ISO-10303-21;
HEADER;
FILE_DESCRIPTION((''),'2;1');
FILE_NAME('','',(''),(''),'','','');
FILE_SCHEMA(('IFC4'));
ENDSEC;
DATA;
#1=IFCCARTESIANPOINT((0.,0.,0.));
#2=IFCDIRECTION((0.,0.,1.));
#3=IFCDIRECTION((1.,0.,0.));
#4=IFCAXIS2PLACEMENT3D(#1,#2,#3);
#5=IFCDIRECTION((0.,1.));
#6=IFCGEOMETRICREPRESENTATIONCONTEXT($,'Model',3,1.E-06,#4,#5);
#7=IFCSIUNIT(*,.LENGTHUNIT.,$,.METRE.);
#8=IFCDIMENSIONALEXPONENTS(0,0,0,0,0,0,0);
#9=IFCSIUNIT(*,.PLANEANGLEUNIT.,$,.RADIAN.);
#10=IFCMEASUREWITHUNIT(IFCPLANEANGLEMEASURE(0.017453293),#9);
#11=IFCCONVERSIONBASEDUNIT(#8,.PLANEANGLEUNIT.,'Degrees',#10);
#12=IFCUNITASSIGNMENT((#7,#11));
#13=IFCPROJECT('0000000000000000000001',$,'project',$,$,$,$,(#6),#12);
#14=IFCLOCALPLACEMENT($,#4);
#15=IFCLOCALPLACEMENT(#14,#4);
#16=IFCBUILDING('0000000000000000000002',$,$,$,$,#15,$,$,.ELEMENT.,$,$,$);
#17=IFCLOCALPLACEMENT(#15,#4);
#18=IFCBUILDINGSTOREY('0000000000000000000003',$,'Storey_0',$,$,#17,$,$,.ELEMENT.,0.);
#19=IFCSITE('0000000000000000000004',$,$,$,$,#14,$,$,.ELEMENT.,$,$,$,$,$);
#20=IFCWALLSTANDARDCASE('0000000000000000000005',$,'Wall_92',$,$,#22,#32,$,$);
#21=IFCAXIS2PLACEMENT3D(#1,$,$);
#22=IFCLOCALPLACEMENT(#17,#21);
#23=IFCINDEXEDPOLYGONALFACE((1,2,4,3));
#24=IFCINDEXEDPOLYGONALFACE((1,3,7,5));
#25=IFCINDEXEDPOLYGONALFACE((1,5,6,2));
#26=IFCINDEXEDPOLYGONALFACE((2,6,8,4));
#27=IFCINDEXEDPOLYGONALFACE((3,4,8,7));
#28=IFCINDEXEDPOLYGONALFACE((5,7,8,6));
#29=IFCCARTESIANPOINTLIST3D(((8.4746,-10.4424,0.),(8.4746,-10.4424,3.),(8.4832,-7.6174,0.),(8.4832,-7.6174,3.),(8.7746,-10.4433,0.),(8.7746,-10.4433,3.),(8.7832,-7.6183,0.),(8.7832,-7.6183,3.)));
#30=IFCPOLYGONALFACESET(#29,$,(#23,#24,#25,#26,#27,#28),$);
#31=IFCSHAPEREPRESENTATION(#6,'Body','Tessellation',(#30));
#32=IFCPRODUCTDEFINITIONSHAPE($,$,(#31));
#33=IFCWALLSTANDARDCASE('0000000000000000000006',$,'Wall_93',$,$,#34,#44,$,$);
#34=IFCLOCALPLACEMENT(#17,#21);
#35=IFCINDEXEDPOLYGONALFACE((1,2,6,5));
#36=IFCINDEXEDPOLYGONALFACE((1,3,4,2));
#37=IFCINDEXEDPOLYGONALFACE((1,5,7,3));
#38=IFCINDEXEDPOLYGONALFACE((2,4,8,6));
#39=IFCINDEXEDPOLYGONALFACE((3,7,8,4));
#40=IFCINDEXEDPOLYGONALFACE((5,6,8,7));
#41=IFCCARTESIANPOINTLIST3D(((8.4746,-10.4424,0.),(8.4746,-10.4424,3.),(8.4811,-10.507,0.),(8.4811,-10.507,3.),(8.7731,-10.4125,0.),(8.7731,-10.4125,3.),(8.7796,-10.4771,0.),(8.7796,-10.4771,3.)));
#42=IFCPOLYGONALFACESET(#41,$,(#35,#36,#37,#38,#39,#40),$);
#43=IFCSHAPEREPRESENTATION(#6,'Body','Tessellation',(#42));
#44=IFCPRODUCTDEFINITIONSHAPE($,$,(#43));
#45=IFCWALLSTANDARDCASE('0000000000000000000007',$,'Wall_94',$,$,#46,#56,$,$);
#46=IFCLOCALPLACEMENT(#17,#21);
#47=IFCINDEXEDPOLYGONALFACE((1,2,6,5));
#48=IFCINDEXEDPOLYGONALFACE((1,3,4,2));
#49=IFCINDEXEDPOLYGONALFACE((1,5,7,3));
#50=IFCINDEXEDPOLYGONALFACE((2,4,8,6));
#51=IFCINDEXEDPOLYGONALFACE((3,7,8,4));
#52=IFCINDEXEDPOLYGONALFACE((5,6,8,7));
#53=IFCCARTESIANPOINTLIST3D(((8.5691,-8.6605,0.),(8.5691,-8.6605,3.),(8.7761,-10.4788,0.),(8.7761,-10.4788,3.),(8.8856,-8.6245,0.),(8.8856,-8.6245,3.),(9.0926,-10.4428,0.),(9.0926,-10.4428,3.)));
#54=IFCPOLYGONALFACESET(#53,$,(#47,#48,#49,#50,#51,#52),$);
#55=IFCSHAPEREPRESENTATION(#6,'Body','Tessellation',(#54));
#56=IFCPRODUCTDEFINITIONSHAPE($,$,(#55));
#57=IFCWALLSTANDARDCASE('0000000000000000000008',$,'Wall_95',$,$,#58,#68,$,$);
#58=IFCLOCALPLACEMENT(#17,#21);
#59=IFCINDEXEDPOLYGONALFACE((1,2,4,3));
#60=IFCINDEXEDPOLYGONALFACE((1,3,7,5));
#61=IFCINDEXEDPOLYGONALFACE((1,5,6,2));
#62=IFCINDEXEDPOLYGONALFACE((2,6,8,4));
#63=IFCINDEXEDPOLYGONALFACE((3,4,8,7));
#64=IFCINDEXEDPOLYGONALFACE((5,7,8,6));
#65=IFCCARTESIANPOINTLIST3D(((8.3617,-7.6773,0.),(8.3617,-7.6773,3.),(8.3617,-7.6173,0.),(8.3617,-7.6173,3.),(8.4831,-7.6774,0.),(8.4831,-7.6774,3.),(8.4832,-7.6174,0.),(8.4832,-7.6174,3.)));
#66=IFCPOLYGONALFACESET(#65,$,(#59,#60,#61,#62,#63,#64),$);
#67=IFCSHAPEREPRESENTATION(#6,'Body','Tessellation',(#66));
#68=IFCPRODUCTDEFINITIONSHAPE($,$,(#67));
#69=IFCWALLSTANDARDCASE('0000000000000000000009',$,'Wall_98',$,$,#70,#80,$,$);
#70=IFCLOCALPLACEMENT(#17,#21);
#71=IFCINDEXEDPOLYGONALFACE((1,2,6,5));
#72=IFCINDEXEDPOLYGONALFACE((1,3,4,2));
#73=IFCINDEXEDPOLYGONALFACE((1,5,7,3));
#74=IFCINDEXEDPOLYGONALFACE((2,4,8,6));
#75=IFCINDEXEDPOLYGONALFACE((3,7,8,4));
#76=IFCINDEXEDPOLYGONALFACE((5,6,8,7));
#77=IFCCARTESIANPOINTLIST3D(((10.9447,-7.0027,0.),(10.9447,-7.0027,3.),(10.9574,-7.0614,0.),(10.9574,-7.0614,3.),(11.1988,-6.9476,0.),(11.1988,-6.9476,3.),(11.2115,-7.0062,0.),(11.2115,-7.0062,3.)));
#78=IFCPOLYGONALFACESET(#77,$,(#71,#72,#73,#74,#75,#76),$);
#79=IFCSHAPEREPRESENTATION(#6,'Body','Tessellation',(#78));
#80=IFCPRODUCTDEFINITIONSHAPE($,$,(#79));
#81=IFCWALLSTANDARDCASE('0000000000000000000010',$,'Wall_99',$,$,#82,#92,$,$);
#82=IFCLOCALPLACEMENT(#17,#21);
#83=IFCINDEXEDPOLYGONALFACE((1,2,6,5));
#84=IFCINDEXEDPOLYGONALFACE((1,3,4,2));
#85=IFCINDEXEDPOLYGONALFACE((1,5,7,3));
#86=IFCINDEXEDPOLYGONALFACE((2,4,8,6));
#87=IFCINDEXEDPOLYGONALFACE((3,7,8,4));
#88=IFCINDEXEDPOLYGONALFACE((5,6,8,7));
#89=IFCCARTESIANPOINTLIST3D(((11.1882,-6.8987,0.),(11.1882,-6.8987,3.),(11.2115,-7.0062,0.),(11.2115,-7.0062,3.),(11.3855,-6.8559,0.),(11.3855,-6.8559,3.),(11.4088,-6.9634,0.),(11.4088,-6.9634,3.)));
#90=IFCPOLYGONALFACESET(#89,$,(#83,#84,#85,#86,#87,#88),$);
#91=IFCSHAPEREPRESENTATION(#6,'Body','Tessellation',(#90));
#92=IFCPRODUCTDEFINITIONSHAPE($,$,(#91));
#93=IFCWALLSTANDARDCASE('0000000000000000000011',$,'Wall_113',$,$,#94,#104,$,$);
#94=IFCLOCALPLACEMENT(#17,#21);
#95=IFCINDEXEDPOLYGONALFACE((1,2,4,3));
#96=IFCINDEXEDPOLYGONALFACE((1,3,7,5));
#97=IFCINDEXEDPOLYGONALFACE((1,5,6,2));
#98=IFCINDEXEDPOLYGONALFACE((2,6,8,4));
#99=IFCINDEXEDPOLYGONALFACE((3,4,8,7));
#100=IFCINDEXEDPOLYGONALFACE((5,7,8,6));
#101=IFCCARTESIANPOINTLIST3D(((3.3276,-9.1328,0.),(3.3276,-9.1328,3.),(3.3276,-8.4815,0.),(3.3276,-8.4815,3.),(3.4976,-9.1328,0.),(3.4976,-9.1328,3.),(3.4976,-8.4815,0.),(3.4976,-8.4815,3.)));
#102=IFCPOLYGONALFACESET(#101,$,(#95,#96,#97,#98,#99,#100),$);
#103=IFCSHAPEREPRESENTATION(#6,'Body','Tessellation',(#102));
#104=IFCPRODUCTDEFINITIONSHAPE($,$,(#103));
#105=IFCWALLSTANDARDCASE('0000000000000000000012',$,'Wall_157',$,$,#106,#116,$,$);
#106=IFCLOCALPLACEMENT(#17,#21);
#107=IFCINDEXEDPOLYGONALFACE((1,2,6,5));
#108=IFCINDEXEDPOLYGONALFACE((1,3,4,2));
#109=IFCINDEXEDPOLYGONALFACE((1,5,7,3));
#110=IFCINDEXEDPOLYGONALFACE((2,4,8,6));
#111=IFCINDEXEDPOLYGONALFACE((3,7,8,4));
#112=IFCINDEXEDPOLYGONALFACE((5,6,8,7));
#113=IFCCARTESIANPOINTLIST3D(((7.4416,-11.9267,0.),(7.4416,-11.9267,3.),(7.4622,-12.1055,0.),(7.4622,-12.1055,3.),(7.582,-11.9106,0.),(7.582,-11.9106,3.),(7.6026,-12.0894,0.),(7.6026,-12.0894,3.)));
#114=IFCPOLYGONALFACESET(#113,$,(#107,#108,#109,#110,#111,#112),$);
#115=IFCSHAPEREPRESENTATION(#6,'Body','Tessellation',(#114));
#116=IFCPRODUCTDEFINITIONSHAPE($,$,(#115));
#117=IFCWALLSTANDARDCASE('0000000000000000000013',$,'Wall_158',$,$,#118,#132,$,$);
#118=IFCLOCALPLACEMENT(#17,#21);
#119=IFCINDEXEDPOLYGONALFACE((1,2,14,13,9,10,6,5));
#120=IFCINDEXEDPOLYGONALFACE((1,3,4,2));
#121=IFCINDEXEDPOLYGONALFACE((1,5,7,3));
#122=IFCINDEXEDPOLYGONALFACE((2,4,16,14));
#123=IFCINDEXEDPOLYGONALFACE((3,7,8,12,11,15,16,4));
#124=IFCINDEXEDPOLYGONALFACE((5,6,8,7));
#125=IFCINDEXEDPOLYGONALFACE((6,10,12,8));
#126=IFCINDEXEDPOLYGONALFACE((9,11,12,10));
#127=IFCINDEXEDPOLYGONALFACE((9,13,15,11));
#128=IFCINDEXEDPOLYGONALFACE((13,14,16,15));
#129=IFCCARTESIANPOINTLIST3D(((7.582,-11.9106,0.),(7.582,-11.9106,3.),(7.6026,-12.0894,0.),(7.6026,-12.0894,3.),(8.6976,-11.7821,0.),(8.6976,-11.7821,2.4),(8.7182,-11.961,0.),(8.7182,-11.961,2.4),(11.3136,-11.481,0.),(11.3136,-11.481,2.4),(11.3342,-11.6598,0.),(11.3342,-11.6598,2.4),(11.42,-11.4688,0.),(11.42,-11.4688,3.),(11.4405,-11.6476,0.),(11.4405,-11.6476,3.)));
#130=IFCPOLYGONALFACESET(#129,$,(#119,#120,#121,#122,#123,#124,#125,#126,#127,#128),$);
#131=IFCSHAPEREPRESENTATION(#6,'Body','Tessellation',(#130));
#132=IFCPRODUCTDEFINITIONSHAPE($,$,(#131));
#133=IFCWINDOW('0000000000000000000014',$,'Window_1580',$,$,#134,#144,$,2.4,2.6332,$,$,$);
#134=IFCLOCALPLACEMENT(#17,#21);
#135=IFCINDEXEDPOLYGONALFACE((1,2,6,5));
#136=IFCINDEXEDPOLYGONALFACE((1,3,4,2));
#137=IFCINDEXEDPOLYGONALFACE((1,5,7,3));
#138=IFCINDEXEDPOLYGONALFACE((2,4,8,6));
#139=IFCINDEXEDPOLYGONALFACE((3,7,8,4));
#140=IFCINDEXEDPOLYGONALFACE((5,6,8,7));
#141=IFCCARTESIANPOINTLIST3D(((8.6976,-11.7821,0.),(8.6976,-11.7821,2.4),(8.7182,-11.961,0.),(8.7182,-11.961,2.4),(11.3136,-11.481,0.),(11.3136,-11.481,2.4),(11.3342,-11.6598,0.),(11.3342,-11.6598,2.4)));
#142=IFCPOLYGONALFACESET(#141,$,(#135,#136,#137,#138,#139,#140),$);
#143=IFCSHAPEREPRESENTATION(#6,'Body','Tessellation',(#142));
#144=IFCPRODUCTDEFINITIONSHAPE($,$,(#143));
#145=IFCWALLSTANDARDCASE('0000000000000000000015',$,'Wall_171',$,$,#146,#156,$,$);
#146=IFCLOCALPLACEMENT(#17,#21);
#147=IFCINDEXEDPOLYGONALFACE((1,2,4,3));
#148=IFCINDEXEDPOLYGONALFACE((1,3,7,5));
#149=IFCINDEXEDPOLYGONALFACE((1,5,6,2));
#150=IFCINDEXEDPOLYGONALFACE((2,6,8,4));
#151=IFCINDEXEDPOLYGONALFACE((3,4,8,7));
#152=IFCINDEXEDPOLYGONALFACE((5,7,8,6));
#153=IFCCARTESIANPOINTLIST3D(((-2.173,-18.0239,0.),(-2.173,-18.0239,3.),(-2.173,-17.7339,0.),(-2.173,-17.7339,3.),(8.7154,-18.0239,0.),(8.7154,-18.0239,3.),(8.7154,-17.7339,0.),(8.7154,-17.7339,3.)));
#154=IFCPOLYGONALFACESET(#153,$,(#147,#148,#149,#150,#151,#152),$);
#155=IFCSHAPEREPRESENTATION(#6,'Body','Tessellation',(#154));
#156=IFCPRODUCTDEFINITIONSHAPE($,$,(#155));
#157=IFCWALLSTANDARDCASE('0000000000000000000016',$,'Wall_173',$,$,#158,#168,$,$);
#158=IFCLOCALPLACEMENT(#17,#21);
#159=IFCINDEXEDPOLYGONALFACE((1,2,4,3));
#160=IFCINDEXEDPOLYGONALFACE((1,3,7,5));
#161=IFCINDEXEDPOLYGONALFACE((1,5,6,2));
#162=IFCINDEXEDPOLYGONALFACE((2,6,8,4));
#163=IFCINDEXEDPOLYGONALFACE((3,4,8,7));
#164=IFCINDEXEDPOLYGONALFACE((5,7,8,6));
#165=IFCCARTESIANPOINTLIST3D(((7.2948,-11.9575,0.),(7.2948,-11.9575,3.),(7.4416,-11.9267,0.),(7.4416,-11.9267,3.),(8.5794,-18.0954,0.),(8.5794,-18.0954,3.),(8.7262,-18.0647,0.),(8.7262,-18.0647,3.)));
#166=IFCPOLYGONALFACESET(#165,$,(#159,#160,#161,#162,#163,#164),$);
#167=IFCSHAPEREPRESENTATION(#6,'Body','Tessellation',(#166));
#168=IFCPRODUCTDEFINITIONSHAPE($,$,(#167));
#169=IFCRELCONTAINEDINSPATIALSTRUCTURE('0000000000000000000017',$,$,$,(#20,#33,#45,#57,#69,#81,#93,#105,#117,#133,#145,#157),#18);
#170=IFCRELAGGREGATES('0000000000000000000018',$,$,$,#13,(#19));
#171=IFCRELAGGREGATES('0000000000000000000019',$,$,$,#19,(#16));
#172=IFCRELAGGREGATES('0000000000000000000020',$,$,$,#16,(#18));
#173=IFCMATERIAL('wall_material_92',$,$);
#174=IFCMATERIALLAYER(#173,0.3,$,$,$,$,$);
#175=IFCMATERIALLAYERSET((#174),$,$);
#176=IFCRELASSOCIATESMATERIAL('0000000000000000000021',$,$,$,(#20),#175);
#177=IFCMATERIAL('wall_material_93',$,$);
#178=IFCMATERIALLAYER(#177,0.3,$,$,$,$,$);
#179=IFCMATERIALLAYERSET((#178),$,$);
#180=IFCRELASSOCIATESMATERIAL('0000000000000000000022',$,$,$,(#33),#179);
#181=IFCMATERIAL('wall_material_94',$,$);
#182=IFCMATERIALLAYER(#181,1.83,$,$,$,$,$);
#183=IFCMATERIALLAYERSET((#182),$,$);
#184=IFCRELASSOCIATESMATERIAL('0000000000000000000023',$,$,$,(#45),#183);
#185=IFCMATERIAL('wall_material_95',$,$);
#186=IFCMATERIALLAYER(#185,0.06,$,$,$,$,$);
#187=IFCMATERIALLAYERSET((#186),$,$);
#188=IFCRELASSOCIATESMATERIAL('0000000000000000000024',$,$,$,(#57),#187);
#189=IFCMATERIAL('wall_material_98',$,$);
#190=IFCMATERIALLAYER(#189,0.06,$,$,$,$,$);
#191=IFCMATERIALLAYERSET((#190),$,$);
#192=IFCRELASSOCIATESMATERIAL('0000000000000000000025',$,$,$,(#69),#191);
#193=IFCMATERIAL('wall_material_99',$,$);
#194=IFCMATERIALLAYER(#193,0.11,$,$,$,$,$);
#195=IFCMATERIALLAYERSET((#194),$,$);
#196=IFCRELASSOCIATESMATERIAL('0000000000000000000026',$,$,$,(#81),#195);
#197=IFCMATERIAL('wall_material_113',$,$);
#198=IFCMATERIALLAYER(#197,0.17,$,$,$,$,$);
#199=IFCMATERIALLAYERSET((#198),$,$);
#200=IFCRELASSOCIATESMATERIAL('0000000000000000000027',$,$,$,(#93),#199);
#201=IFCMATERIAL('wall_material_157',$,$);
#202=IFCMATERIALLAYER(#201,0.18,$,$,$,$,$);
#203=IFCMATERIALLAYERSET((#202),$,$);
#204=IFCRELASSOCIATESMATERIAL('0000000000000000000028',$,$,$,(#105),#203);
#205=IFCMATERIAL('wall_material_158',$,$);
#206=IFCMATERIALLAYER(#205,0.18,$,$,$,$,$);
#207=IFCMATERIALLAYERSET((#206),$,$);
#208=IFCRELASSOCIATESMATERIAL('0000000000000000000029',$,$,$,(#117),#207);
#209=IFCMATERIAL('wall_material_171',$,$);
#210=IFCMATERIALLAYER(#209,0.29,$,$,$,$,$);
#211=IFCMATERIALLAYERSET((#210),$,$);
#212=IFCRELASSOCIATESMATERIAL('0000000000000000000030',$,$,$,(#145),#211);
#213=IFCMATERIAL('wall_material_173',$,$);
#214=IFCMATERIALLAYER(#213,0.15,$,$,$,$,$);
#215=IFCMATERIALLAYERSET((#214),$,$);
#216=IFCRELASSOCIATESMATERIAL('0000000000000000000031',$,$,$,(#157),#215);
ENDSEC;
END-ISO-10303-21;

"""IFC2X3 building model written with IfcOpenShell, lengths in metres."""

from ifc_helpers import new_model, entity, si_unit, converted_unit, direction, frame, frame_2d, origin_with_axes, place, context, project, spatial, polyline, rectangle, outline, extrude, material, layer, layer_set, layer_usage, element, fill, save


model = new_model("IFC2X3")

# Units and contexts
model_context = context("Model", 3, precision=1e-06, world=origin_with_axes(), true_north=direction((0.0, 1.0)))
ifc_project = project(units=[si_unit("LENGTHUNIT", "METRE"), converted_unit("PLANEANGLEUNIT", "Degrees", entity("IfcPlaneAngleMeasure", 0.017453293), si_unit("PLANEANGLEUNIT", "RADIAN"), dimensions=[0, 0, 0, 0, 0, 0, 0])], contexts=[model_context])

# Site, building, storey
site_placement = place(None, origin_with_axes())
site = spatial("IfcSite", under=ifc_project, at=site_placement, CompositionType="ELEMENT")
building_placement = place(site_placement, origin_with_axes())
building = spatial("IfcBuilding", under=site, at=building_placement, CompositionType="ELEMENT")
storey_placement = place(building_placement, origin_with_axes())
storey = spatial("IfcBuildingStorey", under=building, at=storey_placement, Name="Storey_0", CompositionType="ELEMENT", Elevation=0.0)

# Walls
ifc_material_1 = material(Name="wall_material_92")
ifc_layer_1 = layer(ifc_material_1, 0.3)
ifc_layer_set_1 = layer_set([ifc_layer_1])
ifc_layer_usage_1 = layer_usage(ifc_layer_set_1, "AXIS2", "POSITIVE", 0.0)
wall_1_placement = place(storey_placement, frame((8.4832, -7.6174, 0.0), z_axis=(0.0, 0.0, 1.0), x_axis=(-0.003012, -0.999995, 0.0)))
element("IfcWallStandardCase", 1, at=wall_1_placement, inside=storey, material=ifc_layer_usage_1, Name="Wall_92", context=model_context, shape_type="SweptSolid", body=[
    extrude(outline(polyline([(0.0, 0.3), (2.825, 0.3), (2.825, 0.0), (0.0, 0.0), (0.0, 0.3)])), origin_with_axes(), (0.0, 0.0, 1.0), 3.0),
])
ifc_material_2 = material(Name="wall_material_93")
ifc_layer_2 = layer(ifc_material_2, 0.3)
ifc_layer_set_2 = layer_set([ifc_layer_2])
ifc_layer_usage_2 = layer_usage(ifc_layer_set_2, "AXIS2", "POSITIVE", 0.0)
wall_2_placement = place(storey_placement, frame((8.4746, -10.4424, 0.0), z_axis=(0.0, 0.0, 1.0), x_axis=(0.099721, -0.995015, 0.0)))
element("IfcWallStandardCase", 2, at=wall_2_placement, inside=storey, material=ifc_layer_usage_2, Name="Wall_93", context=model_context, shape_type="SweptSolid", body=[
    extrude(outline(polyline([(0.0, 0.3), (0.065, 0.3), (0.065, 0.0), (0.0, 0.0), (0.0, 0.3)])), origin_with_axes(), (0.0, 0.0, 1.0), 3.0),
])
ifc_material_3 = material(Name="wall_material_94")
ifc_layer_3 = layer(ifc_material_3, 1.83)
ifc_layer_set_3 = layer_set([ifc_layer_3])
ifc_layer_usage_3 = layer_usage(ifc_layer_set_3, "AXIS2", "POSITIVE", 0.0)
wall_3_placement = place(storey_placement, frame((8.7761, -10.4788, 0.0), z_axis=(0.0, 0.0, 1.0), x_axis=(0.993582, 0.113117, 0.0)))
element("IfcWallStandardCase", 3, at=wall_3_placement, inside=storey, material=ifc_layer_usage_3, Name="Wall_94", context=model_context, shape_type="SweptSolid", body=[
    extrude(outline(polyline([(0.0, 1.83), (0.3185, 1.83), (0.3185, 0.0), (0.0, 0.0), (0.0, 1.83)])), origin_with_axes(), (0.0, 0.0, 1.0), 3.0),
])
ifc_material_4 = material(Name="wall_material_95")
ifc_layer_4 = layer(ifc_material_4, 0.06)
ifc_layer_set_4 = layer_set([ifc_layer_4])
ifc_layer_usage_4 = layer_usage(ifc_layer_set_4, "AXIS2", "NEGATIVE", 0.0)
wall_4_placement = place(storey_placement, frame((8.4831, -7.6774, 0.0), z_axis=(0.0, 0.0, 1.0), x_axis=(-1.0, 0.000144, 0.0)))
element("IfcWallStandardCase", 4, at=wall_4_placement, inside=storey, material=ifc_layer_usage_4, Name="Wall_95", context=model_context, shape_type="SweptSolid", body=[
    extrude(outline(polyline([(0.0, 0.0), (0.1214, 0.0), (0.1214, -0.06), (0.0, -0.06), (0.0, 0.0)])), origin_with_axes(), (0.0, 0.0, 1.0), 3.0),
])
ifc_material_5 = material(Name="wall_material_98")
ifc_layer_5 = layer(ifc_material_5, 0.06)
ifc_layer_set_5 = layer_set([ifc_layer_5])
ifc_layer_usage_5 = layer_usage(ifc_layer_set_5, "AXIS2", "POSITIVE", 0.0)
wall_5_placement = place(storey_placement, frame((10.9574, -7.0614, 0.0), z_axis=(0.0, 0.0, 1.0), x_axis=(0.977251, 0.212087, 0.0)))
element("IfcWallStandardCase", 5, at=wall_5_placement, inside=storey, material=ifc_layer_usage_5, Name="Wall_98", context=model_context, shape_type="SweptSolid", body=[
    extrude(outline(polyline([(0.0, 0.06), (0.26, 0.06), (0.26, 0.0), (0.0, 0.0), (0.0, 0.06)])), origin_with_axes(), (0.0, 0.0, 1.0), 3.0),
])
ifc_material_6 = material(Name="wall_material_99")
ifc_layer_6 = layer(ifc_material_6, 0.11)
ifc_layer_set_6 = layer_set([ifc_layer_6])
ifc_layer_usage_6 = layer_usage(ifc_layer_set_6, "AXIS2", "POSITIVE", 0.0)
wall_6_placement = place(storey_placement, frame((11.2115, -7.0062, 0.0), z_axis=(0.0, 0.0, 1.0), x_axis=(0.977251, 0.212087, 0.0)))
element("IfcWallStandardCase", 6, at=wall_6_placement, inside=storey, material=ifc_layer_usage_6, Name="Wall_99", context=model_context, shape_type="SweptSolid", body=[
    extrude(outline(polyline([(0.0, 0.11), (0.2019, 0.11), (0.2019, 0.0), (0.0, 0.0), (0.0, 0.11)])), origin_with_axes(), (0.0, 0.0, 1.0), 3.0),
])
ifc_material_7 = material(Name="wall_material_113")
ifc_layer_7 = layer(ifc_material_7, 0.17)
ifc_layer_set_7 = layer_set([ifc_layer_7])
ifc_layer_usage_7 = layer_usage(ifc_layer_set_7, "AXIS2", "NEGATIVE", 0.0)
wall_7_placement = place(storey_placement, frame((3.4976, -8.4815, 0.0), z_axis=(0.0, 0.0, 1.0), x_axis=(0.0, -1.0, 0.0)))
element("IfcWallStandardCase", 7, at=wall_7_placement, inside=storey, material=ifc_layer_usage_7, Name="Wall_113", context=model_context, shape_type="SweptSolid", body=[
    extrude(outline(polyline([(0.0, 0.0), (0.6513, 0.0), (0.6513, -0.17), (0.0, -0.17), (0.0, 0.0)])), origin_with_axes(), (0.0, 0.0, 1.0), 3.0),
])
ifc_material_8 = material(Name="wall_material_157")
ifc_layer_8 = layer(ifc_material_8, 0.18)
ifc_layer_set_8 = layer_set([ifc_layer_8])
ifc_layer_usage_8 = layer_usage(ifc_layer_set_8, "AXIS2", "NEGATIVE", 0.0)
wall_8_placement = place(storey_placement, frame((7.4416, -11.9267, 0.0), z_axis=(0.0, 0.0, 1.0), x_axis=(0.993439, 0.114359, 0.0)))
element("IfcWallStandardCase", 8, at=wall_8_placement, inside=storey, material=ifc_layer_usage_8, Name="Wall_157", context=model_context, shape_type="SweptSolid", body=[
    extrude(outline(polyline([(0.0, 0.0), (0.1413, 0.0), (0.1413, -0.18), (0.0, -0.18), (0.0, 0.0)])), origin_with_axes(), (0.0, 0.0, 1.0), 3.0),
])

# Wall, opening, window
ifc_material_9 = material(Name="wall_material_158")
ifc_layer_9 = layer(ifc_material_9, 0.18)
ifc_layer_set_9 = layer_set([ifc_layer_9])
ifc_layer_usage_9 = layer_usage(ifc_layer_set_9, "AXIS2", "NEGATIVE", 0.0)
wall_9_placement = place(storey_placement, frame((7.582, -11.9106, 0.0), z_axis=(0.0, 0.0, 1.0), x_axis=(0.993439, 0.114359, 0.0)))
wall_9 = element("IfcWallStandardCase", 9, at=wall_9_placement, inside=storey, material=ifc_layer_usage_9, Name="Wall_158", context=model_context, shape_type="SweptSolid", body=[
    extrude(outline(polyline([(0.0, 0.0), (3.8633, 0.0), (3.8633, -0.18), (0.0, -0.18), (0.0, 0.0)])), origin_with_axes(), (0.0, 0.0, 1.0), 3.0),
])
opening_1_placement = place(wall_9_placement, frame((1.123, 0.0, 0.0), z_axis=(0.0, 0.0, 1.0), x_axis=(1.0, 0.0, 0.0)))
opening_1 = element("IfcOpeningElement", 10, at=opening_1_placement, cuts=wall_9, context=model_context, shape_type="SweptSolid", body=[
    extrude(rectangle(XDim=2.6332, YDim=2.4, at=frame_2d((1.2, -1.3166), x_axis=(0.0, 1.0))), frame((0.0, 0.01, 0.0), z_axis=(0.0, -1.0, 0.0), x_axis=(0.0, 0.0, 1.0)), (0.0, 0.0, 1.0), 0.2),
])
window_1_placement = place(storey_placement, origin_with_axes())
window_1 = element("IfcWindow", 11, at=window_1_placement, inside=storey, Name="Window_1580", OverallHeight=2.4, OverallWidth=2.6332, context=model_context, shape_type="SweptSolid", body=[
    extrude(outline(polyline([(8.6976, -11.7821), (11.3136, -11.481), (11.3342, -11.6598), (8.7182, -11.961), (8.6976, -11.7821)])), origin_with_axes(), (0.0, 0.0, 1.0), 2.4),
])
fill(opening_1, window_1)

# Walls
ifc_material_10 = material(Name="wall_material_171")
ifc_layer_10 = layer(ifc_material_10, 0.29)
ifc_layer_set_10 = layer_set([ifc_layer_10])
ifc_layer_usage_10 = layer_usage(ifc_layer_set_10, "AXIS2", "NEGATIVE", 0.0)
wall_10_placement = place(storey_placement, frame((8.7154, -18.0239, 0.0), z_axis=(0.0, 0.0, 1.0), x_axis=(-1.0, 0.0, 0.0)))
element("IfcWallStandardCase", 12, at=wall_10_placement, inside=storey, material=ifc_layer_usage_10, Name="Wall_171", context=model_context, shape_type="SweptSolid", body=[
    extrude(outline(polyline([(0.0, 0.0), (10.8884, 0.0), (10.8884, -0.29), (0.0, -0.29), (0.0, 0.0)])), origin_with_axes(), (0.0, 0.0, 1.0), 3.0),
])
ifc_material_11 = material(Name="wall_material_173")
ifc_layer_11 = layer(ifc_material_11, 0.15)
ifc_layer_set_11 = layer_set([ifc_layer_11])
ifc_layer_usage_11 = layer_usage(ifc_layer_set_11, "AXIS2", "NEGATIVE", 0.0)
wall_11_placement = place(storey_placement, frame((7.4416, -11.9267, 0.0), z_axis=(0.0, 0.0, 1.0), x_axis=(0.204838, -0.978796, 0.0)))
element("IfcWallStandardCase", 13, at=wall_11_placement, inside=storey, material=ifc_layer_usage_11, Name="Wall_173", context=model_context, shape_type="SweptSolid", body=[
    extrude(outline(polyline([(0.0, 0.0), (6.271, 0.0), (6.271, -0.15), (0.0, -0.15), (0.0, 0.0)])), origin_with_axes(), (0.0, 0.0, 1.0), 3.0),
])

save(model, "model.ifc")
